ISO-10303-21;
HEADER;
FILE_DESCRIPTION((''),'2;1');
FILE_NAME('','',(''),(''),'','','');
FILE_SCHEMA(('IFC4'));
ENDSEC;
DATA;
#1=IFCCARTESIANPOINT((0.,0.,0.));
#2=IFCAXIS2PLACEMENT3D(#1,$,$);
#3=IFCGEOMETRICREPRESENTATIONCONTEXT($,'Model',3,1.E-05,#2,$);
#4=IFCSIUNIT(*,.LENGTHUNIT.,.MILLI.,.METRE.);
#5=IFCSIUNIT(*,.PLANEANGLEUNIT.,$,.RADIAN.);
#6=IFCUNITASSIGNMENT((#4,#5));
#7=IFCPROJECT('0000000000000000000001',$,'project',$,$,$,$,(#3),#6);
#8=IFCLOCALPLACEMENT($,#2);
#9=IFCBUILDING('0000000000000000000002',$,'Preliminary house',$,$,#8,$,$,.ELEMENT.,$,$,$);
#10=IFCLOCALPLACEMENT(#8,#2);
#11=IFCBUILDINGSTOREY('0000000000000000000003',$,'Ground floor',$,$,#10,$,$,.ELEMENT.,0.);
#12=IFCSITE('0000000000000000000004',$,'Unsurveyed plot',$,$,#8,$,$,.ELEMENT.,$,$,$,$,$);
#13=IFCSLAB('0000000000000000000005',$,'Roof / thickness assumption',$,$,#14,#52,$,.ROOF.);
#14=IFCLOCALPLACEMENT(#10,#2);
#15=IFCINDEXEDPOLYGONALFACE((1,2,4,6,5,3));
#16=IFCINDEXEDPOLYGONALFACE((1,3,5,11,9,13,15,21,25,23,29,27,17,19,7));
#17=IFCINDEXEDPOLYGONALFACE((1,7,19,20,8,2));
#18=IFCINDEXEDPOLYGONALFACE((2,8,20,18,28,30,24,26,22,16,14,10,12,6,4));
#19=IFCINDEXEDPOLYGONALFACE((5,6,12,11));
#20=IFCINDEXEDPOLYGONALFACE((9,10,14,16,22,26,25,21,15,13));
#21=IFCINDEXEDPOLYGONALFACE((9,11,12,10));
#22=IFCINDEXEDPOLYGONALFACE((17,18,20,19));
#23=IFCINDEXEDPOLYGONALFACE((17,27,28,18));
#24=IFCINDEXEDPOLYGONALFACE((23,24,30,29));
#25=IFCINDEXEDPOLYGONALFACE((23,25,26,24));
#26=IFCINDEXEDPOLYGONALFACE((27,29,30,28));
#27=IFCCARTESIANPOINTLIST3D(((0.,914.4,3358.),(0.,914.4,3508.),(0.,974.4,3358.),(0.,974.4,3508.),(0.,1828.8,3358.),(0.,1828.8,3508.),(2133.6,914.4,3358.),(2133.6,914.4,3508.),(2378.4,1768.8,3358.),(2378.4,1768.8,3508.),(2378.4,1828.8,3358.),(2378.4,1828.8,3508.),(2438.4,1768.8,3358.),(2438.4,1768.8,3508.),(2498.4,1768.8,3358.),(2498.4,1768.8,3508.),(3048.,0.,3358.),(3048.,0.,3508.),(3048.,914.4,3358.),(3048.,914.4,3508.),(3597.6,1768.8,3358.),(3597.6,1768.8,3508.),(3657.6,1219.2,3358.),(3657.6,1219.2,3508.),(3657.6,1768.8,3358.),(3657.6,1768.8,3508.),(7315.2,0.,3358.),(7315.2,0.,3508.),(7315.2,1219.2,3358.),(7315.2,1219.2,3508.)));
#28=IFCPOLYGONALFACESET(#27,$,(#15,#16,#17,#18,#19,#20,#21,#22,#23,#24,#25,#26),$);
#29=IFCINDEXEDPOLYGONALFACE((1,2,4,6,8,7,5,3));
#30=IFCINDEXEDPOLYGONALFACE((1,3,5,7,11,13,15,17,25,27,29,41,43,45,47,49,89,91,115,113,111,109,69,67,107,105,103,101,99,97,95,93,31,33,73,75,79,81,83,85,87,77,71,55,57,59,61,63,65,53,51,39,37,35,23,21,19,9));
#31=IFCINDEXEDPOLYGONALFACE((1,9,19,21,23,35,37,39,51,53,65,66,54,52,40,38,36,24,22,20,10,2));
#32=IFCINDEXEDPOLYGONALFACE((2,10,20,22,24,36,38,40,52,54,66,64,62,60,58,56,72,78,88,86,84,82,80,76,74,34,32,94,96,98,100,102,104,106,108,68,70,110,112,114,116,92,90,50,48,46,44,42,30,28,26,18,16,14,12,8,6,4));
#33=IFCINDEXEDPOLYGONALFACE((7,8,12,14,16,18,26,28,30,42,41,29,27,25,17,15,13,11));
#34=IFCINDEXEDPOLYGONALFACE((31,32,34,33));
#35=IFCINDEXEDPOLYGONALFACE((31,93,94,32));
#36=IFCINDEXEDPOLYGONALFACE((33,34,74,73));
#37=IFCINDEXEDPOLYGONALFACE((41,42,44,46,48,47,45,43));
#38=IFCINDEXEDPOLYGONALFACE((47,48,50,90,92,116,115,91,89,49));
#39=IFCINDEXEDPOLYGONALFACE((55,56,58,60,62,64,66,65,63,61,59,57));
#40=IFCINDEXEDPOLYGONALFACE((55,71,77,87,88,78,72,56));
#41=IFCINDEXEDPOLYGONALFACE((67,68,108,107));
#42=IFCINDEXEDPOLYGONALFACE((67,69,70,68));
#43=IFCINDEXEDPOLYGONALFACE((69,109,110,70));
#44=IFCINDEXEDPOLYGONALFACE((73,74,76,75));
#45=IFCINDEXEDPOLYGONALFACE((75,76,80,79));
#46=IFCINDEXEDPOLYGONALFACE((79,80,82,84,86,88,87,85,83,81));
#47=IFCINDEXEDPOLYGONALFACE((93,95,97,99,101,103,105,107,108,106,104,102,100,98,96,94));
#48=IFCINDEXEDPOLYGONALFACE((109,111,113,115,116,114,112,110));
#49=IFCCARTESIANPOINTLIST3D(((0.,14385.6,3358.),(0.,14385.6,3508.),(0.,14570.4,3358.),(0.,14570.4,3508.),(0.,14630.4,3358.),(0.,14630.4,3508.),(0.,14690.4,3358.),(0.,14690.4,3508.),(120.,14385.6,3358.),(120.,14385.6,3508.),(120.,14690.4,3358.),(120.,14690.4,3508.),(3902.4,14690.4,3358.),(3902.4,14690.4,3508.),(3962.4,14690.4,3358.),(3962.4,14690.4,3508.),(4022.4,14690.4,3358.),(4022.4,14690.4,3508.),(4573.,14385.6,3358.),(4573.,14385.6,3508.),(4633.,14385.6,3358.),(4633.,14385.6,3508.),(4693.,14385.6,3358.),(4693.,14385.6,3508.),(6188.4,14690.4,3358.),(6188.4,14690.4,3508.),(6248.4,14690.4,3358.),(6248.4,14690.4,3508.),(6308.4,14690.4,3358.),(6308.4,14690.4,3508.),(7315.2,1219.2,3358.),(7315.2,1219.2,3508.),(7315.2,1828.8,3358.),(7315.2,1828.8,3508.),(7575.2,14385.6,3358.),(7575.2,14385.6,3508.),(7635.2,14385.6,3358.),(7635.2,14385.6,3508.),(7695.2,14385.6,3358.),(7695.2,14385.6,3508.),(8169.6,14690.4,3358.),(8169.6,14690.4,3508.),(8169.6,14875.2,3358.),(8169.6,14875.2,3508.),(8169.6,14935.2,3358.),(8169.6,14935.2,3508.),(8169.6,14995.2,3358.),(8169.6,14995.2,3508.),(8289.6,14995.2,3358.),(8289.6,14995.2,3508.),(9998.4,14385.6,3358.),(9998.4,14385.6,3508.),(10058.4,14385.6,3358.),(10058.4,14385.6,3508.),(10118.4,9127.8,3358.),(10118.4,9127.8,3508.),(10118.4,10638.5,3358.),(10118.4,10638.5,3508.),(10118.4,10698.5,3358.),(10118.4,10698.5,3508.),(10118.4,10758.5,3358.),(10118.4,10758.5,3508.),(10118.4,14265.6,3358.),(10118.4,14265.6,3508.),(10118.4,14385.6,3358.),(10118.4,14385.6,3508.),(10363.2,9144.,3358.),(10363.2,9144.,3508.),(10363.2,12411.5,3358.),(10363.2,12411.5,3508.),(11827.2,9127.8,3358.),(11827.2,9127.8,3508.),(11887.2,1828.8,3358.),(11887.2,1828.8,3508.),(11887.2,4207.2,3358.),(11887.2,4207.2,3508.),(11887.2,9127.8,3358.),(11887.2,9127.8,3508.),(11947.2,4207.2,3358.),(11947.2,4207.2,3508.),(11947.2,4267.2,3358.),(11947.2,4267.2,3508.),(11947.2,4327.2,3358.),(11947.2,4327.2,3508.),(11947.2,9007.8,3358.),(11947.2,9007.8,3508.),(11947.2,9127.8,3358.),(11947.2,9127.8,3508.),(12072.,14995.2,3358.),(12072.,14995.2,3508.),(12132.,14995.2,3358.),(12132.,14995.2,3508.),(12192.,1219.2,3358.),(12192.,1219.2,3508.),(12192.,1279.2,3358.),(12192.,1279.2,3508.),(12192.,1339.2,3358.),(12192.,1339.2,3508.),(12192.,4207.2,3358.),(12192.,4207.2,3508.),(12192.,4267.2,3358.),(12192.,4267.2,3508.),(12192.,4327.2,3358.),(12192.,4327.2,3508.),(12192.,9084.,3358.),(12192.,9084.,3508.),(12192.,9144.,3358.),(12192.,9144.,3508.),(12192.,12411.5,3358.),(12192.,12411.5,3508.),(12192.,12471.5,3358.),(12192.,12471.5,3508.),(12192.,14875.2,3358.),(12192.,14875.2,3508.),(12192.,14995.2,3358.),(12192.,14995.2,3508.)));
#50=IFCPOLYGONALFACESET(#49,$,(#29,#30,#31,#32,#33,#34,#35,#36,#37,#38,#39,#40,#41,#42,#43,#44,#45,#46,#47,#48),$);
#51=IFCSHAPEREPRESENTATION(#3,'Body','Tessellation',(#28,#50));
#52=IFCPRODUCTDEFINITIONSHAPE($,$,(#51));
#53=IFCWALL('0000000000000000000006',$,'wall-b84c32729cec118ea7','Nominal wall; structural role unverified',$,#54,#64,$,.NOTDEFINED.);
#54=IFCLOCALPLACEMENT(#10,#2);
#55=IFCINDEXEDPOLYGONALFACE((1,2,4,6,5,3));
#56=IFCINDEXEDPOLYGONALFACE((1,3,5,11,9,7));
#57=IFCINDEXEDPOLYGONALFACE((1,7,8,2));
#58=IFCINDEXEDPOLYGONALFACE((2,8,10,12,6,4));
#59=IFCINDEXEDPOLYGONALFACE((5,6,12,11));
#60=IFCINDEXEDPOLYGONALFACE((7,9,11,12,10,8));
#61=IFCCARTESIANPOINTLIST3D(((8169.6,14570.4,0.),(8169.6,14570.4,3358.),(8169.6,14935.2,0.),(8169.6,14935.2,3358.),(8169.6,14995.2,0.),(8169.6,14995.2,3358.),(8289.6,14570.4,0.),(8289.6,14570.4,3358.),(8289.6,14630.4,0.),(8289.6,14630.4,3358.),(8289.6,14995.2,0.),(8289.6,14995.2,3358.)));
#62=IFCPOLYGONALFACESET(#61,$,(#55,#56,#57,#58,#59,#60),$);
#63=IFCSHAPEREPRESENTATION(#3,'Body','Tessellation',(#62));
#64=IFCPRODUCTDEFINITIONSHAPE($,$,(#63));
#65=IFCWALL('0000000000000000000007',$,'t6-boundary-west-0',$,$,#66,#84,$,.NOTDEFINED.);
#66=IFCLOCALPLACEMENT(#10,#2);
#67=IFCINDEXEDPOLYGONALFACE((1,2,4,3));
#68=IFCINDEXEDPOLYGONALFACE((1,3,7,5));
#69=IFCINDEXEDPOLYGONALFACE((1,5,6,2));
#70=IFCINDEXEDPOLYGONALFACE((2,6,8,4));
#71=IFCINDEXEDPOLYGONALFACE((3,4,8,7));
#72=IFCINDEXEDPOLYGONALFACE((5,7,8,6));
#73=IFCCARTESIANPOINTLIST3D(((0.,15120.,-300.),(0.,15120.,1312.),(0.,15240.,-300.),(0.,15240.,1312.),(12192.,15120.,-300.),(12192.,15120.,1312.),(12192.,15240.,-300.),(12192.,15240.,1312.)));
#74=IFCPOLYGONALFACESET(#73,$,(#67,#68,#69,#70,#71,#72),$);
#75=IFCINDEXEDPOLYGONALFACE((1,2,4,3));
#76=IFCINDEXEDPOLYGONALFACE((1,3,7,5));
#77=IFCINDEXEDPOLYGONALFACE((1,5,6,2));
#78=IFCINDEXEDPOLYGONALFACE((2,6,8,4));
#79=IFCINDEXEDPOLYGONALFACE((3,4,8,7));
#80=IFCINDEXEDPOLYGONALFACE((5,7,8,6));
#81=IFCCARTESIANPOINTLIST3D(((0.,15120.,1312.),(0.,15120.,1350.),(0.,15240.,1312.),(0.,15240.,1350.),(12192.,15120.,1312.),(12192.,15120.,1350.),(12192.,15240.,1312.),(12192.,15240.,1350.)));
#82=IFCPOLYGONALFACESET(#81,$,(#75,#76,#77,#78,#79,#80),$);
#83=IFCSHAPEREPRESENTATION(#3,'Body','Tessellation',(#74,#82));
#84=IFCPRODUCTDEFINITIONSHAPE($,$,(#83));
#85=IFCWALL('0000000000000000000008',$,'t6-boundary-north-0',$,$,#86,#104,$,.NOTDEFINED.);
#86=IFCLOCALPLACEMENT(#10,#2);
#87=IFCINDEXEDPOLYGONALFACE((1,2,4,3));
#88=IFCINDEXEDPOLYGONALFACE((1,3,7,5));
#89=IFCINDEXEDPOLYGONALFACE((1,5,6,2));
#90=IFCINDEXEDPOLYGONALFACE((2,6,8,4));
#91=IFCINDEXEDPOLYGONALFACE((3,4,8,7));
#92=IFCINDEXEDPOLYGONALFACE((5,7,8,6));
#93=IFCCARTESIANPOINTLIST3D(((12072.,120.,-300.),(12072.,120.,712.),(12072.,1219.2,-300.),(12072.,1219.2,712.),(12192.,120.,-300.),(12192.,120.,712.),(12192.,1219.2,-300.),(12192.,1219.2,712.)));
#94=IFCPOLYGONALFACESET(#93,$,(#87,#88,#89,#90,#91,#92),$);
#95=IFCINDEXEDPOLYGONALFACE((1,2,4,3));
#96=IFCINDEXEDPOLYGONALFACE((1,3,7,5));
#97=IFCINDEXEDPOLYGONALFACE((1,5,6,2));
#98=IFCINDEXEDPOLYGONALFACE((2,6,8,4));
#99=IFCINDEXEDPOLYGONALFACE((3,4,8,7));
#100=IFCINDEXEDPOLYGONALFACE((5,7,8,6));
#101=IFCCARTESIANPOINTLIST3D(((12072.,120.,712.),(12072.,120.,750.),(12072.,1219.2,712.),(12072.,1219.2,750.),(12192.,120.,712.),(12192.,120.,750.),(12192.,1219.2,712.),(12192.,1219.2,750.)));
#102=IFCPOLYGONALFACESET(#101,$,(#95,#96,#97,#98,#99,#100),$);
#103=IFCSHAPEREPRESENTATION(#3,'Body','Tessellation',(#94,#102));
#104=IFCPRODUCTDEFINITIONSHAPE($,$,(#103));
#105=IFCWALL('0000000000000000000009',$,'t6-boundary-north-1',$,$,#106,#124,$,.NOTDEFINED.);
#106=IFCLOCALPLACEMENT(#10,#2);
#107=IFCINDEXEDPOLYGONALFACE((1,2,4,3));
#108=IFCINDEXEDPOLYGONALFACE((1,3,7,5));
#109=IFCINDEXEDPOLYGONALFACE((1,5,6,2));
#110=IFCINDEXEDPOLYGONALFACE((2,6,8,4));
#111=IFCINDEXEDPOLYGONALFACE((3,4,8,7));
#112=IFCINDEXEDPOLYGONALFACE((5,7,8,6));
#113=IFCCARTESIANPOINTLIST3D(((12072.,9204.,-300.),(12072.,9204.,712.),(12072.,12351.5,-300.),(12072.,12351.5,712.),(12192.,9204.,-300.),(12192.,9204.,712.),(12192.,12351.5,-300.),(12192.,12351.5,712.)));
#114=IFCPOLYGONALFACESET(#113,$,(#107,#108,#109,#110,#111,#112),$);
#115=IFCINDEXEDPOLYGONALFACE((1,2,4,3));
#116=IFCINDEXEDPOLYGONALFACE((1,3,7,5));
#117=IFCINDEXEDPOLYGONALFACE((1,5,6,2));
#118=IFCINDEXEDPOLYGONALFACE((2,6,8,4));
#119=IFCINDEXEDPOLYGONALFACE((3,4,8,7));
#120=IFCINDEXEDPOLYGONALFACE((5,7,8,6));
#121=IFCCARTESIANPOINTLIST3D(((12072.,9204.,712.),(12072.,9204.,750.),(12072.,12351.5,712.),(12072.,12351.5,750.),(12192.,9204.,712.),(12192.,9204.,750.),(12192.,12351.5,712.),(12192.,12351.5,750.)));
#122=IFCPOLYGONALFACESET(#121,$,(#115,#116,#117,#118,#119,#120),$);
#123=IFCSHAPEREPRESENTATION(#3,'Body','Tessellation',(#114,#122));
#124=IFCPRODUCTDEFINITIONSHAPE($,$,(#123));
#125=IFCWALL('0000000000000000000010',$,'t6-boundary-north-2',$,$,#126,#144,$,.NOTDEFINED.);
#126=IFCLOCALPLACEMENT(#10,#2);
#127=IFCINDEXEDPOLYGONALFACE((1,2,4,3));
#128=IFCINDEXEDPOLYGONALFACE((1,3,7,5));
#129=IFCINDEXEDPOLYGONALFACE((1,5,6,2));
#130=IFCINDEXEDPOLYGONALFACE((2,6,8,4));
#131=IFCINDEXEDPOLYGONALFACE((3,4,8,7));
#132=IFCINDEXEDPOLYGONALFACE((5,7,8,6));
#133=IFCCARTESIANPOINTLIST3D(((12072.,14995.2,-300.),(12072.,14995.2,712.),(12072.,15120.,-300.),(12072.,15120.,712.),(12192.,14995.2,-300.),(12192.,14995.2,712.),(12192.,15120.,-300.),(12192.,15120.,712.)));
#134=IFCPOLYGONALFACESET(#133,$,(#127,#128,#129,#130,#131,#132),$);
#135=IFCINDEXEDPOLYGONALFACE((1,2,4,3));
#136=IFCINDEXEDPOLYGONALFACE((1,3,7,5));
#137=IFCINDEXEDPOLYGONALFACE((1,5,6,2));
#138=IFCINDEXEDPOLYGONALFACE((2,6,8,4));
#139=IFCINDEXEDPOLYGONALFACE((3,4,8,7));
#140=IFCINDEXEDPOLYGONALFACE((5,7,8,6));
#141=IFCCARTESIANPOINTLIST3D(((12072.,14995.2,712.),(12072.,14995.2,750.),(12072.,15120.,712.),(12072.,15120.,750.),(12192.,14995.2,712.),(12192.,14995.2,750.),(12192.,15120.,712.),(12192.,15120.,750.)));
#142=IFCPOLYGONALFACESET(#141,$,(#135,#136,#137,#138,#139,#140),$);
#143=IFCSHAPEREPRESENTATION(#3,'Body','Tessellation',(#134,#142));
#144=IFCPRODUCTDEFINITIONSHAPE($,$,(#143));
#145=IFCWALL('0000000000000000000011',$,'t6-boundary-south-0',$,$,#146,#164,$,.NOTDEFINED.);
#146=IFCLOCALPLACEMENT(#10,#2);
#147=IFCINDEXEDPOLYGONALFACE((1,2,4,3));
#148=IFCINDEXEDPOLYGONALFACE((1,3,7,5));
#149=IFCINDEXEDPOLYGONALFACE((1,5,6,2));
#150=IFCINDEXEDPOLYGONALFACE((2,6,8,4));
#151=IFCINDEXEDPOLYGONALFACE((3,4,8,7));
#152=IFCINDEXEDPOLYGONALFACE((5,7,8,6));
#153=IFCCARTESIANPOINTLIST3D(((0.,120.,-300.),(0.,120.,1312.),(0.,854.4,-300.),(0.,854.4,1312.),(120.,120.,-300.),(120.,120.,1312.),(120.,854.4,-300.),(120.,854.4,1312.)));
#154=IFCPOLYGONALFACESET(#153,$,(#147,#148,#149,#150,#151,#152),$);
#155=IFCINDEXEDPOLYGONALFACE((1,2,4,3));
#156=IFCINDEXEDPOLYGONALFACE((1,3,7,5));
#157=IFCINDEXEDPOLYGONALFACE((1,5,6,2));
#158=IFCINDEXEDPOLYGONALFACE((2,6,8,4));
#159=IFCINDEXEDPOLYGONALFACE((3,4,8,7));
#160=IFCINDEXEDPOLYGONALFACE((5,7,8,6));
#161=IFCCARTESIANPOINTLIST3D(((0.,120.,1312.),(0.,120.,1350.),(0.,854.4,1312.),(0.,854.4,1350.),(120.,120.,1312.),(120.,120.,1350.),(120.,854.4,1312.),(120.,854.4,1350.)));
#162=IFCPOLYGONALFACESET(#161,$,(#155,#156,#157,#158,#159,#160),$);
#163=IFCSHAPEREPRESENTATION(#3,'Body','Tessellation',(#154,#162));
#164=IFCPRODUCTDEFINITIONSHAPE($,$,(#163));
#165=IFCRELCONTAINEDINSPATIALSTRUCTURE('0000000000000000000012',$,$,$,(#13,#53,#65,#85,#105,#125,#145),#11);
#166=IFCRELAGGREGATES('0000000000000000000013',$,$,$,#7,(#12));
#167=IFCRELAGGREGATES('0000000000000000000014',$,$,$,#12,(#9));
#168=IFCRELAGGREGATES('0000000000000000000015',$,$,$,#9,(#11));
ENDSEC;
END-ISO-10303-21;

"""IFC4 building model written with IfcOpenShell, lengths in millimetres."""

from ifc_helpers import new_model, si_unit, frame, origin, place, context, project, spatial, polyline, outline, extrude, element, save


model = new_model("IFC4")

# Units and contexts
model_context = context("Model", 3, precision=1e-05, world=origin())
ifc_project = project(units=[si_unit("LENGTHUNIT", "METRE", prefix="MILLI"), si_unit("PLANEANGLEUNIT", "RADIAN")], contexts=[model_context])

# Site, building, storey
placement_1 = place(None, origin())
site = spatial("IfcSite", under=ifc_project, at=placement_1, Name="Unsurveyed plot", CompositionType="ELEMENT")
building = spatial("IfcBuilding", under=site, at=placement_1, Name="Preliminary house", CompositionType="ELEMENT")
placement_2 = place(placement_1, origin())
storey = spatial("IfcBuildingStorey", under=building, at=placement_2, Name="Ground floor", CompositionType="ELEMENT", Elevation=0.0)

# Slab
element("IfcSlab", 1, at=placement_2, inside=storey, Name="Roof / thickness assumption", PredefinedType="ROOF", context=model_context, shape_type="SweptSolid", body=[
    extrude(outline(polyline([(3048.0, 0.0), (3048.0, 914.4), (2133.6, 914.4), (0.0, 914.4), (0.0, 974.4), (0.0, 1828.8), (2378.4, 1828.8), (2378.4, 1768.8), (2438.4, 1768.8), (2498.4, 1768.8), (3597.6, 1768.8), (3657.6, 1768.8), (3657.6, 1219.2), (7315.2, 1219.2), (7315.2, 0.0), (3048.0, 0.0)])), frame((0.0, 0.0, 3358.0)), (0.0, 0.0, 1.0), 150.0),
    extrude(outline(polyline([(0.0, 14630.4), (0.0, 14690.4), (120.0, 14690.4), (3902.4, 14690.4), (3962.4, 14690.4), (4022.4, 14690.4), (6188.4, 14690.4), (6248.4, 14690.4), (6308.4, 14690.4), (8169.6, 14690.4), (8169.6, 14875.2), (8169.6, 14935.2), (8169.6, 14995.2), (8289.6, 14995.2), (12072.0, 14995.2), (12132.0, 14995.2), (12192.0, 14995.2), (12192.0, 14875.2), (12192.0, 12471.5), (12192.0, 12411.5), (10363.2, 12411.5), (10363.2, 9144.0), (12192.0, 9144.0), (12192.0, 9084.0), (12192.0, 4327.2), (12192.0, 4267.2), (12192.0, 4207.2), (12192.0, 1339.2), (12192.0, 1279.2), (12192.0, 1219.2), (7315.2, 1219.2), (7315.2, 1828.8), (11887.2, 1828.8), (11887.2, 4207.2), (11947.2, 4207.2), (11947.2, 4267.2), (11947.2, 4327.2), (11947.2, 9007.8), (11947.2, 9127.8), (11887.2, 9127.8), (11827.2, 9127.8), (10118.4, 9127.8), (10118.4, 10638.5), (10118.4, 10698.5), (10118.4, 10758.5), (10118.4, 14265.6), (10118.4, 14385.6), (10058.4, 14385.6), (9998.4, 14385.6), (7695.2, 14385.6), (7635.2, 14385.6), (7575.2, 14385.6), (4693.0, 14385.6), (4633.0, 14385.6), (4573.0, 14385.6), (120.0, 14385.6), (0.0, 14385.6), (0.0, 14570.4), (0.0, 14630.4)])), frame((0.0, 0.0, 3358.0)), (0.0, 0.0, 1.0), 150.0),
])

# Wall
element("IfcWall", 2, at=placement_2, inside=storey, Name="wall-b84c32729cec118ea7", Description="Nominal wall; structural role unverified", PredefinedType="NOTDEFINED", context=model_context, shape_type="SweptSolid", body=[
    extrude(outline(polyline([(8169.6, 14935.2), (8169.6, 14995.2), (8289.6, 14995.2), (8289.6, 14630.4), (8289.6, 14570.4), (8169.6, 14570.4), (8169.6, 14935.2)])), origin(), (0.0, 0.0, 1.0), 3358.0),
])

# Walls
element("IfcWall", 3, at=placement_2, inside=storey, Name="t6-boundary-west-0", PredefinedType="NOTDEFINED", context=model_context, shape_type="SweptSolid", body=[
    extrude(outline(polyline([(12192.0, 15120.0), (12192.0, 15240.0), (0.0, 15240.0), (0.0, 15120.0), (12192.0, 15120.0)])), frame((0.0, 0.0, -300.0)), (0.0, 0.0, 1.0), 1612.0),
    extrude(outline(polyline([(12192.0, 15120.0), (12192.0, 15240.0), (0.0, 15240.0), (0.0, 15120.0), (12192.0, 15120.0)])), frame((0.0, 0.0, 1312.0)), (0.0, 0.0, 1.0), 38.0),
])
element("IfcWall", 4, at=placement_2, inside=storey, Name="t6-boundary-north-0", PredefinedType="NOTDEFINED", context=model_context, shape_type="SweptSolid", body=[
    extrude(outline(polyline([(12192.0, 120.0), (12192.0, 1219.2), (12072.0, 1219.2), (12072.0, 120.0), (12192.0, 120.0)])), frame((0.0, 0.0, -300.0)), (0.0, 0.0, 1.0), 1012.0),
    extrude(outline(polyline([(12192.0, 120.0), (12192.0, 1219.2), (12072.0, 1219.2), (12072.0, 120.0), (12192.0, 120.0)])), frame((0.0, 0.0, 712.0)), (0.0, 0.0, 1.0), 38.0),
])
element("IfcWall", 5, at=placement_2, inside=storey, Name="t6-boundary-north-1", PredefinedType="NOTDEFINED", context=model_context, shape_type="SweptSolid", body=[
    extrude(outline(polyline([(12192.0, 9204.0), (12192.0, 12351.5), (12072.0, 12351.5), (12072.0, 9204.0), (12192.0, 9204.0)])), frame((0.0, 0.0, -300.0)), (0.0, 0.0, 1.0), 1012.0),
    extrude(outline(polyline([(12192.0, 9204.0), (12192.0, 12351.5), (12072.0, 12351.5), (12072.0, 9204.0), (12192.0, 9204.0)])), frame((0.0, 0.0, 712.0)), (0.0, 0.0, 1.0), 38.0),
])
element("IfcWall", 6, at=placement_2, inside=storey, Name="t6-boundary-north-2", PredefinedType="NOTDEFINED", context=model_context, shape_type="SweptSolid", body=[
    extrude(outline(polyline([(12192.0, 14995.2), (12192.0, 15120.0), (12072.0, 15120.0), (12072.0, 14995.2), (12192.0, 14995.2)])), frame((0.0, 0.0, -300.0)), (0.0, 0.0, 1.0), 1012.0),
    extrude(outline(polyline([(12192.0, 14995.2), (12192.0, 15120.0), (12072.0, 15120.0), (12072.0, 14995.2), (12192.0, 14995.2)])), frame((0.0, 0.0, 712.0)), (0.0, 0.0, 1.0), 38.0),
])
element("IfcWall", 7, at=placement_2, inside=storey, Name="t6-boundary-south-0", PredefinedType="NOTDEFINED", context=model_context, shape_type="SweptSolid", body=[
    extrude(outline(polyline([(120.0, 120.0), (120.0, 854.4), (0.0, 854.4), (0.0, 120.0), (120.0, 120.0)])), frame((0.0, 0.0, -300.0)), (0.0, 0.0, 1.0), 1612.0),
    extrude(outline(polyline([(120.0, 120.0), (120.0, 854.4), (0.0, 854.4), (0.0, 120.0), (120.0, 120.0)])), frame((0.0, 0.0, 1312.0)), (0.0, 0.0, 1.0), 38.0),
])

save(model, "model.ifc")
